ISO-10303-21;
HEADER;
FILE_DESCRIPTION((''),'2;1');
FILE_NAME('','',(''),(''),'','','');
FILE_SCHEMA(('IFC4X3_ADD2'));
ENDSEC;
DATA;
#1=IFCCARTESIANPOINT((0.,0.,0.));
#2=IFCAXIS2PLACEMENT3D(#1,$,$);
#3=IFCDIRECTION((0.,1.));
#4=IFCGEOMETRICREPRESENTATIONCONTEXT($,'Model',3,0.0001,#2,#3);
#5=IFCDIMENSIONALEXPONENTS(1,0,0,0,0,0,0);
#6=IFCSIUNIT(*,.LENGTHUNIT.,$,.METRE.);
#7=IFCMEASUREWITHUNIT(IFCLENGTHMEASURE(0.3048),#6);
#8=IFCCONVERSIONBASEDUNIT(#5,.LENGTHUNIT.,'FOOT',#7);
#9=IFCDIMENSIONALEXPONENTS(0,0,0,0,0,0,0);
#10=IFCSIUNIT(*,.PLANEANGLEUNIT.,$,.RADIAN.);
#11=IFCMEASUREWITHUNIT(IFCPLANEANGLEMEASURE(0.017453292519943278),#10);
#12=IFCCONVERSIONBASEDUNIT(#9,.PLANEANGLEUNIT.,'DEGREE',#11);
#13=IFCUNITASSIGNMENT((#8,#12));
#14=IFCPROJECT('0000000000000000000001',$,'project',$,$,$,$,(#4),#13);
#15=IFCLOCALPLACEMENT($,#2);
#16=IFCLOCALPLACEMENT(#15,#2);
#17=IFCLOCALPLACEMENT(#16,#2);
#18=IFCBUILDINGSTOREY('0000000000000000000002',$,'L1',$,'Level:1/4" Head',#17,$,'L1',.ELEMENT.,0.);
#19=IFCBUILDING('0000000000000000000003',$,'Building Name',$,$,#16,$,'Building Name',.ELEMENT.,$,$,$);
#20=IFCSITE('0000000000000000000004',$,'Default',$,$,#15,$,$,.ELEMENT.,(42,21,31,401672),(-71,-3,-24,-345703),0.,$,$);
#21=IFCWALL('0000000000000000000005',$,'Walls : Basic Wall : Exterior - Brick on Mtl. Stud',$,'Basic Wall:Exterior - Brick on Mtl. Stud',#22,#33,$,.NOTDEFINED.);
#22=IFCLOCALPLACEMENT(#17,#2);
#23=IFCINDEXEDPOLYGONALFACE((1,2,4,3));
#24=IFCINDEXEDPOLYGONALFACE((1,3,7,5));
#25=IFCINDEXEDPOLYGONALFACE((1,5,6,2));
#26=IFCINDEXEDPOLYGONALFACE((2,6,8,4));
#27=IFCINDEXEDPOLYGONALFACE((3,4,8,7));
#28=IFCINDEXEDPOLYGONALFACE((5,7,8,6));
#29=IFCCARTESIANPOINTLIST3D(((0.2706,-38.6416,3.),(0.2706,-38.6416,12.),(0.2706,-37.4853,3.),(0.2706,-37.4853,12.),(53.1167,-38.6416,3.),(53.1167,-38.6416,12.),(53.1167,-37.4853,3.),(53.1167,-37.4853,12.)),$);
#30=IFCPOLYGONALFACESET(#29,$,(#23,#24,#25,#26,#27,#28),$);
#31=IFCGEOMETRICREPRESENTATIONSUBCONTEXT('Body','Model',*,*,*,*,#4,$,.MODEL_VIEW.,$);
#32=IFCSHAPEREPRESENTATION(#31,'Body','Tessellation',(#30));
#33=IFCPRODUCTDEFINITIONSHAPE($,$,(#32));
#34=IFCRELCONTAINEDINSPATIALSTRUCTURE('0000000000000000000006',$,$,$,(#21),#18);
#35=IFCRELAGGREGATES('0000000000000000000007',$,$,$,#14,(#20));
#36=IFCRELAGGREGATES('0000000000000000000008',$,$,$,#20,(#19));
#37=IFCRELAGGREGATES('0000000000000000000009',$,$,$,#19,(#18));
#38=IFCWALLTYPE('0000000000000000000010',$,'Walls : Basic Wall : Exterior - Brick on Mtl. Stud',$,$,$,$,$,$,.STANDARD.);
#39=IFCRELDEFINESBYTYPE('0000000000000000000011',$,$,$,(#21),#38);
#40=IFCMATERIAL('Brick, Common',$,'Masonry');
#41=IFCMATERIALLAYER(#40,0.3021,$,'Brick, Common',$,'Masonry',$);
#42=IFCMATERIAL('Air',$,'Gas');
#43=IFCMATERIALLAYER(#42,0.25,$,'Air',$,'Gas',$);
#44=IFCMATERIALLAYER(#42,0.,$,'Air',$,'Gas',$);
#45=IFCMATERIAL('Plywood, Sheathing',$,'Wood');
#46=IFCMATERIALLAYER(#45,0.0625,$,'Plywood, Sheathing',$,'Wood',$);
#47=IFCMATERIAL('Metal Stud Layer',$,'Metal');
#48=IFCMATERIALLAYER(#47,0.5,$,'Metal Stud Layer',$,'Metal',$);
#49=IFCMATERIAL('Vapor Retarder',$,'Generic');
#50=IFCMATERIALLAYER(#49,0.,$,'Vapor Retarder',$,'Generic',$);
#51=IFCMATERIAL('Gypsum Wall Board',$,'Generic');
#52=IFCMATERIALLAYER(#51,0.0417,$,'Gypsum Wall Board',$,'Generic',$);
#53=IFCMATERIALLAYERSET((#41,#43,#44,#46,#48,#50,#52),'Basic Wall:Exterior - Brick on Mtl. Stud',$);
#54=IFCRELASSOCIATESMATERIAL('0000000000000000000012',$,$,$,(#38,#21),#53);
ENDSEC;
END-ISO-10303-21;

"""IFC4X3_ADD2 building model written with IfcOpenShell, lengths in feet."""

from ifc_helpers import new_model, entity, si_unit, converted_unit, direction, frame, frame_2d, origin, place, context, subcontext, project, spatial, rectangle, extrude, material, layer, layer_set, type_object, element, save


model = new_model("IFC4X3_ADD2")

# Units and contexts
model_context = context("Model", 3, precision=0.0001, world=origin(), true_north=direction((0.0, 1.0)))
body_context = subcontext(model_context, "Body", "Model", "MODEL_VIEW")
ifc_project = project(units=[converted_unit("LENGTHUNIT", "FOOT", entity("IfcLengthMeasure", 0.3048), si_unit("LENGTHUNIT", "METRE"), dimensions=[1, 0, 0, 0, 0, 0, 0]), converted_unit("PLANEANGLEUNIT", "DEGREE", entity("IfcPlaneAngleMeasure", 0.017453292519943278), si_unit("PLANEANGLEUNIT", "RADIAN"), dimensions=[0, 0, 0, 0, 0, 0, 0])], contexts=[model_context])

# Site, building, storey
site_placement = place(None, origin())
site = spatial("IfcSite", under=ifc_project, at=site_placement, Name="Default", CompositionType="ELEMENT", RefLatitude=(42, 21, 31, 401672), RefLongitude=(-71, -3, -24, -345703), RefElevation=0.0)
building_placement = place(site_placement, origin())
building = spatial("IfcBuilding", under=site, at=building_placement, Name="Building Name", LongName="Building Name", CompositionType="ELEMENT")
storey_placement = place(building_placement, origin())
storey = spatial("IfcBuildingStorey", under=building, at=storey_placement, Name="L1", ObjectType="Level:1/4\" Head", LongName="L1", CompositionType="ELEMENT", Elevation=0.0)

# Shared definitions
ifc_material_1 = material(Name="Plywood, Sheathing", Category="Wood")

# Wall
ifc_material_2 = material(Name="Air", Category="Gas")
ifc_material_3 = material(Name="Metal Stud Layer", Category="Metal")
ifc_material_4 = material(Name="Vapor Retarder", Category="Generic")
ifc_material_5 = material(Name="Gypsum Wall Board", Category="Generic")
ifc_material_6 = material(Name="Brick, Common", Category="Masonry")
ifc_layer_1 = layer(ifc_material_6, 0.3021, Name="Brick, Common", Category="Masonry")
ifc_layer_2 = layer(ifc_material_2, 0.25, Name="Air", Category="Gas")
ifc_layer_3 = layer(ifc_material_2, 0.0, Name="Air", Category="Gas")
ifc_layer_4 = layer(ifc_material_1, 0.0625, Name="Plywood, Sheathing", Category="Wood")
ifc_layer_5 = layer(ifc_material_3, 0.5, Name="Metal Stud Layer", Category="Metal")
ifc_layer_6 = layer(ifc_material_4, 0.0, Name="Vapor Retarder", Category="Generic")
ifc_layer_7 = layer(ifc_material_5, 0.0417, Name="Gypsum Wall Board", Category="Generic")
ifc_layer_set_1 = layer_set([ifc_layer_1, ifc_layer_2, ifc_layer_3, ifc_layer_4, ifc_layer_5, ifc_layer_6, ifc_layer_7], Name="Basic Wall:Exterior - Brick on Mtl. Stud")
wall_type_1 = type_object("IfcWallType", Name="Walls : Basic Wall : Exterior - Brick on Mtl. Stud", PredefinedType="STANDARD", material=ifc_layer_set_1)
wall_1_placement = place(storey_placement, frame((53.1167, -38.0635, 3.0), z_axis=(0.0, 0.0, 1.0), x_axis=(-1.0, 0.0, 0.0)))
element("IfcWall", 1, at=wall_1_placement, inside=storey, type_object=wall_type_1, material=ifc_layer_set_1, Name="Walls : Basic Wall : Exterior - Brick on Mtl. Stud", ObjectType="Basic Wall:Exterior - Brick on Mtl. Stud", PredefinedType="NOTDEFINED", context=body_context, shape_type="SweptSolid", body=[
    extrude(rectangle(XDim=52.8461, YDim=1.1562, at=frame_2d((26.423, 0.0), x_axis=(-1.0, 0.0))), origin(), (0.0, 0.0, 1.0), 9.0),
])

save(model, "model.ifc")
